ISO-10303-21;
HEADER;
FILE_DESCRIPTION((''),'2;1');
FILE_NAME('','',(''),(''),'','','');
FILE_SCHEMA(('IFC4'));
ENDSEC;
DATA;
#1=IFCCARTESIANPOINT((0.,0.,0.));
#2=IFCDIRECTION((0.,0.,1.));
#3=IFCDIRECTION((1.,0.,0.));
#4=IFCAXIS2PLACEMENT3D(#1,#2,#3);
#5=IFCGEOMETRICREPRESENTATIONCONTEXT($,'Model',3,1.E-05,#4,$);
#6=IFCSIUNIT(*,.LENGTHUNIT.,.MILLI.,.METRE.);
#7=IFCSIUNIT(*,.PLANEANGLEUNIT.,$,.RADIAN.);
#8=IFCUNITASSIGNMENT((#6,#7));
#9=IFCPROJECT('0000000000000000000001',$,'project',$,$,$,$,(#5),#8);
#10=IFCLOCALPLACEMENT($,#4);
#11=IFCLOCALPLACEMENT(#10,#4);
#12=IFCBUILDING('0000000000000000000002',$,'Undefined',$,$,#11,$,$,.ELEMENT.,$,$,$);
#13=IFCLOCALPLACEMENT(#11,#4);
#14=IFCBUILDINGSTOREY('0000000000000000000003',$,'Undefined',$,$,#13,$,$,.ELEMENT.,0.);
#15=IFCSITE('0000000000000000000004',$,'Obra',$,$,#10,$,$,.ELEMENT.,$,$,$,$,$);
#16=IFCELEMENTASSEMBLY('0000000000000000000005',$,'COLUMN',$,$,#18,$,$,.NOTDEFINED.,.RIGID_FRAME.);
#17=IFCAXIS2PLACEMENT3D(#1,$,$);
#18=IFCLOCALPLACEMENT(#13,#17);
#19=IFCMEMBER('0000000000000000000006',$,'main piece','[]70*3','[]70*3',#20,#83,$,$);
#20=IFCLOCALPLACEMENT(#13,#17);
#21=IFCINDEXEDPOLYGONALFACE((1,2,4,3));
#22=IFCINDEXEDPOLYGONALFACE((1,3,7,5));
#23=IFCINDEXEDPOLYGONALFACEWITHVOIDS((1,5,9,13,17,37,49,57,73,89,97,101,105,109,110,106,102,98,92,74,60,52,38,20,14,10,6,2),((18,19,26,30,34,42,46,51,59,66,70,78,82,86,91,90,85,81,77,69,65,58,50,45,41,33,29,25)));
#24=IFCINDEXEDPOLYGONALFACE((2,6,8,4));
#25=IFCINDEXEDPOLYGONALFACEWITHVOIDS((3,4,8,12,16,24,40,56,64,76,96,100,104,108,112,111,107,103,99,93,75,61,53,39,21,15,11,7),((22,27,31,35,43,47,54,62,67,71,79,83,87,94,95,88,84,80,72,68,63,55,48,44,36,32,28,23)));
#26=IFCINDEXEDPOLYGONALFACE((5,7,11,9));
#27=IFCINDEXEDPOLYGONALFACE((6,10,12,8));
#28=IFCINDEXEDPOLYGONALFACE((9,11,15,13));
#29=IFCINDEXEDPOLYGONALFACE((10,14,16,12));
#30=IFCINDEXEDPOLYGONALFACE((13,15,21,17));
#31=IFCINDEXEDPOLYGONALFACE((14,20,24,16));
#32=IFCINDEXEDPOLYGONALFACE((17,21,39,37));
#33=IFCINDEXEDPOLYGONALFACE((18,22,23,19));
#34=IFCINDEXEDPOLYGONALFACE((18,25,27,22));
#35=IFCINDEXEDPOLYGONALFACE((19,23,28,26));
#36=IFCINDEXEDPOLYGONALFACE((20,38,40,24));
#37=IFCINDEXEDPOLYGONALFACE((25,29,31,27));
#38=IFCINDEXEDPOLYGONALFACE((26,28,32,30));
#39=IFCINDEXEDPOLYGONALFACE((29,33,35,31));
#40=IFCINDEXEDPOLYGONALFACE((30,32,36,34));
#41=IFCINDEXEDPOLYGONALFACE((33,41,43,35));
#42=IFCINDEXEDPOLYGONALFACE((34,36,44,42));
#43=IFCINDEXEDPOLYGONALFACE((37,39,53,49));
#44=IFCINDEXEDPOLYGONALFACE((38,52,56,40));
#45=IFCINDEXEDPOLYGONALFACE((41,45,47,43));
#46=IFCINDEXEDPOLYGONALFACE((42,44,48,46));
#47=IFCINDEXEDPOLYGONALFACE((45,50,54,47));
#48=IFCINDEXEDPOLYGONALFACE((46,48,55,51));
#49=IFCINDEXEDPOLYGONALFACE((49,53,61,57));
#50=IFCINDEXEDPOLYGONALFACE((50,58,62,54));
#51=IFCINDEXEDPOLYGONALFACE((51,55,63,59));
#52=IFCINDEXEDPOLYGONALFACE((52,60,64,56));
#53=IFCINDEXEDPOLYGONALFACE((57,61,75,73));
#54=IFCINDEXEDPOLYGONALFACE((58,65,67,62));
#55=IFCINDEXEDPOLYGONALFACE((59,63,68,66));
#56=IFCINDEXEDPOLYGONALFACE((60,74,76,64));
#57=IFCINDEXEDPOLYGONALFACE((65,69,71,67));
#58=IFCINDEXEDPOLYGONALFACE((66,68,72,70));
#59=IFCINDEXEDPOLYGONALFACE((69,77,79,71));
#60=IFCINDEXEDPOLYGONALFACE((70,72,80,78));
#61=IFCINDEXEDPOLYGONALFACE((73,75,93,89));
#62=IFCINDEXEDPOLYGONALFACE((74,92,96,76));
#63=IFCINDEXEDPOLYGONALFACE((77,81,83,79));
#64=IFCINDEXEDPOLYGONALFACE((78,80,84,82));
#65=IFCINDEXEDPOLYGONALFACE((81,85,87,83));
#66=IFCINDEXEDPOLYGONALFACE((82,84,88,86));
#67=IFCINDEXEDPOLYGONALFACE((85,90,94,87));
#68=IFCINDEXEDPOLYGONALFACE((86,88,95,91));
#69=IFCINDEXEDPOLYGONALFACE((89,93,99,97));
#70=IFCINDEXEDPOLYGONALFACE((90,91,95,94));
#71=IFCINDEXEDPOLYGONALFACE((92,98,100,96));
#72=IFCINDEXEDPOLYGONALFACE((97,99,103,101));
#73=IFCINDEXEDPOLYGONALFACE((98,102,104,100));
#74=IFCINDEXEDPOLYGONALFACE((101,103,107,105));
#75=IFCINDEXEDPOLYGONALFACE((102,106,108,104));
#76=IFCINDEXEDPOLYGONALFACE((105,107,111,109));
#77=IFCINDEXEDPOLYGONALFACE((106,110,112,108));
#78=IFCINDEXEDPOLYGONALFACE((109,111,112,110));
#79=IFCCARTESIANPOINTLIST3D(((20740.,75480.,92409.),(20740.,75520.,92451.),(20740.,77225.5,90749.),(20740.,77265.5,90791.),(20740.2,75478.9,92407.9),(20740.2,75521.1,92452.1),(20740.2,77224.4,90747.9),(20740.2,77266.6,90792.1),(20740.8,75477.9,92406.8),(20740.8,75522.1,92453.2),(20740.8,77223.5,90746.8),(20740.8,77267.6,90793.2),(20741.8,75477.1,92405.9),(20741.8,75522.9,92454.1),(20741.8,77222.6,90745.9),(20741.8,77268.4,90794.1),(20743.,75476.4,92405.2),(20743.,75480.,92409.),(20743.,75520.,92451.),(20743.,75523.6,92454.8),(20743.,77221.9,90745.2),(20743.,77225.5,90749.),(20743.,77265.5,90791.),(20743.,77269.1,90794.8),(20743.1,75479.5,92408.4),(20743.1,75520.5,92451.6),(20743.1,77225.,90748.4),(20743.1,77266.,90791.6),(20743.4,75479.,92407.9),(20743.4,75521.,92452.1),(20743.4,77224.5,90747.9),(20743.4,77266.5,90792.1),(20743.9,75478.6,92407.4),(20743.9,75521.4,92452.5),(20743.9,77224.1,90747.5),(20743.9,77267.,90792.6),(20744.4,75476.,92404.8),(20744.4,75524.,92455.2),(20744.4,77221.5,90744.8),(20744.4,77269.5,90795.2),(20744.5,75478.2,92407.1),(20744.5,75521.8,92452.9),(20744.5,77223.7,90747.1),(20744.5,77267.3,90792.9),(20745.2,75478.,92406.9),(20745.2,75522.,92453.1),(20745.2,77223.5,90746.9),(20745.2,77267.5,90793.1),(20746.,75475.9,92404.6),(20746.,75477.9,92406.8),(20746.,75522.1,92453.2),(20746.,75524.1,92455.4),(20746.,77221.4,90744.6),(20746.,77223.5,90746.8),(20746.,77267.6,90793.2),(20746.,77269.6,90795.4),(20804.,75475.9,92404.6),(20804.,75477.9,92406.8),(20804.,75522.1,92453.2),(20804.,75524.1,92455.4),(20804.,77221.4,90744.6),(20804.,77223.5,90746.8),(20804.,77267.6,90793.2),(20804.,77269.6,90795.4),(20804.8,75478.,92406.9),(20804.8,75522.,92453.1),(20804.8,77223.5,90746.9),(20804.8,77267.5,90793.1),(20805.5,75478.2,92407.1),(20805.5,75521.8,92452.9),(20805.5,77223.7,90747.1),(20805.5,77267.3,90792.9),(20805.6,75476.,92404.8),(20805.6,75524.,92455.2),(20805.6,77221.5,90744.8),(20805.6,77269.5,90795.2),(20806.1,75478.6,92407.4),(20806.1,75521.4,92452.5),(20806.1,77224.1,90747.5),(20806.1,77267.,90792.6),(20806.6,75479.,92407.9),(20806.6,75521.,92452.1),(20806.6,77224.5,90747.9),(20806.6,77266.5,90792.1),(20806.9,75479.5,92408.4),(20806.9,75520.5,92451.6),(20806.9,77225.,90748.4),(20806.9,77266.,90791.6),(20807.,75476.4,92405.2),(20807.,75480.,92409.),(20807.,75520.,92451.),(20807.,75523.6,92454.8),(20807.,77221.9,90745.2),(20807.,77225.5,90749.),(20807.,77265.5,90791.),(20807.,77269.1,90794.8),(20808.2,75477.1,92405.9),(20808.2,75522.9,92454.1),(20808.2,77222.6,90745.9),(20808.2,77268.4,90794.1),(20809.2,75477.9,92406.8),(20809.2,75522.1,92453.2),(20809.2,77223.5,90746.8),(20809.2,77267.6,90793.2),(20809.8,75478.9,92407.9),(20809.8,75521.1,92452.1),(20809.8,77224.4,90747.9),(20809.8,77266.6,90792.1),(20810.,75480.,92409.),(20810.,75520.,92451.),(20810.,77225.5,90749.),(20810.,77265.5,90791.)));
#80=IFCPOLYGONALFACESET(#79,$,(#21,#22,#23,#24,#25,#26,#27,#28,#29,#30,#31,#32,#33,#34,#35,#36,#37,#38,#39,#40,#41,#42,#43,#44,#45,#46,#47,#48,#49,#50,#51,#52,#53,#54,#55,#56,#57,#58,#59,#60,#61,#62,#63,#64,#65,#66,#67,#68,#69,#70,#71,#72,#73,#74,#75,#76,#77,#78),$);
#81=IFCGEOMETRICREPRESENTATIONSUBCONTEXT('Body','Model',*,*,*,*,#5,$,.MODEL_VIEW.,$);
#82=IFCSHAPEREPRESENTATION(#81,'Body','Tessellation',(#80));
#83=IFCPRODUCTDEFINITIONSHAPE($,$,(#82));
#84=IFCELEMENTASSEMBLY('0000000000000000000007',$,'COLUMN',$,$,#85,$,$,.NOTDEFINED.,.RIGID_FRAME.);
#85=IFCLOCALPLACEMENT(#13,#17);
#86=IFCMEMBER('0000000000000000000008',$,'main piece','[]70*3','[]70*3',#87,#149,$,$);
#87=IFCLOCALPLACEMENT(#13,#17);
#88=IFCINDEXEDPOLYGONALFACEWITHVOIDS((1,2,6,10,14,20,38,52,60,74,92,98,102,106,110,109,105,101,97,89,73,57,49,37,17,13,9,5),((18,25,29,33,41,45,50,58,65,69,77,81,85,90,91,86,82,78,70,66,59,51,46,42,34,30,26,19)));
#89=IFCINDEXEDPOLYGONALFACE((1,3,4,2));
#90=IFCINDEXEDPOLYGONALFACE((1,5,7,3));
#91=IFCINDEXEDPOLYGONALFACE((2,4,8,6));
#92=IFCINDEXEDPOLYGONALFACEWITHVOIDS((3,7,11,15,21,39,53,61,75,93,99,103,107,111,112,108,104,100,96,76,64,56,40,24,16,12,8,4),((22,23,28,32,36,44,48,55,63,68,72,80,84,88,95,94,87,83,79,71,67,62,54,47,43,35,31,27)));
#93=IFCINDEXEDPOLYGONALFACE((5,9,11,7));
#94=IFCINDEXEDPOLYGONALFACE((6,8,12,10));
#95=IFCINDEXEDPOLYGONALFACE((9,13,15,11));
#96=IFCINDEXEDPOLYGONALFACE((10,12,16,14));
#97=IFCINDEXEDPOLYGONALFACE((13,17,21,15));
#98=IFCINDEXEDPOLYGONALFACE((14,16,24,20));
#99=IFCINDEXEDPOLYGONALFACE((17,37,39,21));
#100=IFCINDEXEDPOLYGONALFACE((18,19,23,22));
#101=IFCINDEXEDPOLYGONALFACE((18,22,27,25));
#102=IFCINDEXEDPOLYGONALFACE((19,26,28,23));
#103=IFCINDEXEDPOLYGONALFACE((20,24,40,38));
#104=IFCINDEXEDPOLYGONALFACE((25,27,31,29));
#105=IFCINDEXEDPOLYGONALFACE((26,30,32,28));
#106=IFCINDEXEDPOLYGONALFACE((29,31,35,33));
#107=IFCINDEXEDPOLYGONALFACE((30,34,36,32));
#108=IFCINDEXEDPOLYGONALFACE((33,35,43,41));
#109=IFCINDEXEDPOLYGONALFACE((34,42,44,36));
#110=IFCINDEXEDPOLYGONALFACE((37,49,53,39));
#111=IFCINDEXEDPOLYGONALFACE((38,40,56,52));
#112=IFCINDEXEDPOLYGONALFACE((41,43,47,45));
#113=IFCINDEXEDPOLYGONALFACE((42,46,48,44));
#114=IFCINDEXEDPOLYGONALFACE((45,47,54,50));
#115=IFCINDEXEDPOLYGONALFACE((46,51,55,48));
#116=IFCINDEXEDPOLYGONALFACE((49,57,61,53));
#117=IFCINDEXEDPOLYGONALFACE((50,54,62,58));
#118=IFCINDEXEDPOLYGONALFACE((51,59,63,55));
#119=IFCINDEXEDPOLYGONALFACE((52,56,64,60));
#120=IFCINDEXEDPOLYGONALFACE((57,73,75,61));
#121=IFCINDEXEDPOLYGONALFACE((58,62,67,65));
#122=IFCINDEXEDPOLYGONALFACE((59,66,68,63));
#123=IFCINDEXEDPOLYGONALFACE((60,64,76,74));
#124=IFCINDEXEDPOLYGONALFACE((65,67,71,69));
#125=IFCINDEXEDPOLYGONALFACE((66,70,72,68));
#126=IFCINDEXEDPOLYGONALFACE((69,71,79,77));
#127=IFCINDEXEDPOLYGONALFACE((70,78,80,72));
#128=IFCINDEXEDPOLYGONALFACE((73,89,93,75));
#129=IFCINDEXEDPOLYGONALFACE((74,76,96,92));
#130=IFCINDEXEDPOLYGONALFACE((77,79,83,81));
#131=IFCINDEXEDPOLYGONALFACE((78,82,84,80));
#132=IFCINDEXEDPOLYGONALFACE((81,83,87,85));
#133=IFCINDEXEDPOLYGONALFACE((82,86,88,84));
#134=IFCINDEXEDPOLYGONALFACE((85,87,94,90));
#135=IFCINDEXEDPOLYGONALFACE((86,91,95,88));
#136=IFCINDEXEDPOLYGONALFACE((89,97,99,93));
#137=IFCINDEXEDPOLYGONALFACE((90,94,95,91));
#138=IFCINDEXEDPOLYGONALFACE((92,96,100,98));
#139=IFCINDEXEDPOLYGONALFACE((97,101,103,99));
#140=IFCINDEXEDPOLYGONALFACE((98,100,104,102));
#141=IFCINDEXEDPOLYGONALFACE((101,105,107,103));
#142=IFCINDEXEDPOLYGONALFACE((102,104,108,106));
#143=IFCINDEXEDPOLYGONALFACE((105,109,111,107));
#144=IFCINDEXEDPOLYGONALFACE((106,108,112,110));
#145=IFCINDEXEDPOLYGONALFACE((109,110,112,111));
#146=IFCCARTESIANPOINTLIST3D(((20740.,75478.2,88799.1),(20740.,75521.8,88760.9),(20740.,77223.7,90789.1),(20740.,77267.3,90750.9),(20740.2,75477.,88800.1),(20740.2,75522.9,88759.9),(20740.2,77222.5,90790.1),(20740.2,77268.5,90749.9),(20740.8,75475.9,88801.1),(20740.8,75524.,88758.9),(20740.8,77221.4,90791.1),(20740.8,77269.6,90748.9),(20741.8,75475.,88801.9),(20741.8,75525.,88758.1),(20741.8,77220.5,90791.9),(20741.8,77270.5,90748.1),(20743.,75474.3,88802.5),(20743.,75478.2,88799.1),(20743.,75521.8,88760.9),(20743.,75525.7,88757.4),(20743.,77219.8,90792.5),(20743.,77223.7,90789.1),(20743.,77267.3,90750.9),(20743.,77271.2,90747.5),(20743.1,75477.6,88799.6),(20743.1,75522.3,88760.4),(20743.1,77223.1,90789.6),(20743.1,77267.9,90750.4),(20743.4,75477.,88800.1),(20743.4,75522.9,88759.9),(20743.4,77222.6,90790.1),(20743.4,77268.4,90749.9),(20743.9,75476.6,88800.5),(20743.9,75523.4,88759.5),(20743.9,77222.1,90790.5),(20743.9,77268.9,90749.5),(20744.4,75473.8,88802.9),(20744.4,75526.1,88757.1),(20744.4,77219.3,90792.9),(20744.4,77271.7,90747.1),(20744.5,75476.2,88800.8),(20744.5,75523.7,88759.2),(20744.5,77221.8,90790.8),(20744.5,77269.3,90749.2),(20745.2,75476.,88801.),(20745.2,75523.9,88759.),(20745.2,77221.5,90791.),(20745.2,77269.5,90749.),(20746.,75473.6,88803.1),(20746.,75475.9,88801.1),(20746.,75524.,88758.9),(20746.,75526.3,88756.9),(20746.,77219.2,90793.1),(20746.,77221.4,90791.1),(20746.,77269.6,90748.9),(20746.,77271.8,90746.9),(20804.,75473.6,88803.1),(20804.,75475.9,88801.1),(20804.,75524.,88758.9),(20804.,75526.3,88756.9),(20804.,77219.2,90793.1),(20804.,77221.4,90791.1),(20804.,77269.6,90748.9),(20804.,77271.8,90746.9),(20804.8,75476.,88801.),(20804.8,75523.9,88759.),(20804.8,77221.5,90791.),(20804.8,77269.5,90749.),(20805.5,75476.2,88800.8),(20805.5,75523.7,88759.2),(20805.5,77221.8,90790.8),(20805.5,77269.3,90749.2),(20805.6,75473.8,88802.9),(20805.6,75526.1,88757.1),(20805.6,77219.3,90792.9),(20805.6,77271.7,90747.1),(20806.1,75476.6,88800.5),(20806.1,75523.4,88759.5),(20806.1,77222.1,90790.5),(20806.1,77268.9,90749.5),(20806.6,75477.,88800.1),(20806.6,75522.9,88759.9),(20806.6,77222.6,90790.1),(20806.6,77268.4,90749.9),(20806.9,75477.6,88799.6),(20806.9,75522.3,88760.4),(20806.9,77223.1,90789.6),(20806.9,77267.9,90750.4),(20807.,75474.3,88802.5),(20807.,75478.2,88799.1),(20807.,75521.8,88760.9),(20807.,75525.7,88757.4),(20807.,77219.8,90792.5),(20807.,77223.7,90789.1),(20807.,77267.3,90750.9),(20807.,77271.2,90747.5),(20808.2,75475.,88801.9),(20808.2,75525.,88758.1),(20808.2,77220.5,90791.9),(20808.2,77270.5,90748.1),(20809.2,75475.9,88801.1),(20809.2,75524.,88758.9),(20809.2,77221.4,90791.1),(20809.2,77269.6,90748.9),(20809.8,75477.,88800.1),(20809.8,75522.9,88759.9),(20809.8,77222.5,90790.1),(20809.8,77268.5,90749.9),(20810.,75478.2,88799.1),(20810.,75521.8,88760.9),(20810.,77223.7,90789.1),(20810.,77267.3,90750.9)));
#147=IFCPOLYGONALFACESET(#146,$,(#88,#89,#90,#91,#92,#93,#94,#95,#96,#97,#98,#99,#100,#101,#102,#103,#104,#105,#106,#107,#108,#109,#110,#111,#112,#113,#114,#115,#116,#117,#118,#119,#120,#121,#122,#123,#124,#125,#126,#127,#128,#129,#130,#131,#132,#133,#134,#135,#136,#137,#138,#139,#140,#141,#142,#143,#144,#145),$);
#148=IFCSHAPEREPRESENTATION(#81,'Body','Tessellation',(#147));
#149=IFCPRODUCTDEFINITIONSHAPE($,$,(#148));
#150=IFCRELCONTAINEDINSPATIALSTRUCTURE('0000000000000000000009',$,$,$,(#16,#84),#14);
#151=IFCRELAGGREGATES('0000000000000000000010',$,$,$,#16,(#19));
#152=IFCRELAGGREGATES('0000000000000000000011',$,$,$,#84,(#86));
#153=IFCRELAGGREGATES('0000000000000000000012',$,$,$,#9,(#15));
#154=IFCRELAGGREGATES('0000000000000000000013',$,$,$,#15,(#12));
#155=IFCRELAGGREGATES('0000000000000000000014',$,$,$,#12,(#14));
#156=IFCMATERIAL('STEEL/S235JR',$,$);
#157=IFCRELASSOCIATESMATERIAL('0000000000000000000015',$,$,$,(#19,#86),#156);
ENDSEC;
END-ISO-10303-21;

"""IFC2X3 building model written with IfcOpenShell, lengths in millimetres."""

from ifc_helpers import new_model, si_unit, frame, origin_with_axes, origin_2d_with_axis, place, context, subcontext, project, spatial, hollow_rectangle, extrude, material, element, aggregate, save


model = new_model("IFC2X3")

# Units and contexts
model_context = context("Model", 3, precision=1e-05, world=origin_with_axes())
body_context = subcontext(model_context, "Body", "Model", "MODEL_VIEW")
ifc_project = project(units=[si_unit("LENGTHUNIT", "METRE", prefix="MILLI"), si_unit("PLANEANGLEUNIT", "RADIAN")], contexts=[model_context])

# Site, building, storey
site_placement = place(None, origin_with_axes())
site = spatial("IfcSite", under=ifc_project, at=site_placement, Name="Obra", CompositionType="ELEMENT")
building_placement = place(site_placement, origin_with_axes())
building = spatial("IfcBuilding", under=site, at=building_placement, Name="Undefined", CompositionType="ELEMENT")
storey_placement = place(building_placement, origin_with_axes())
storey = spatial("IfcBuildingStorey", under=building, at=storey_placement, Name="Undefined", CompositionType="ELEMENT", Elevation=0.0)

# Shared definitions
ifc_material = material(Name="STEEL/S235JR")

# Element assemblies, members
assembly_1_placement = place(storey_placement, origin_with_axes())
assembly_1 = element("IfcElementAssembly", 1, at=assembly_1_placement, inside=storey, Name="COLUMN", AssemblyPlace="NOTDEFINED", PredefinedType="RIGID_FRAME")
member_1_placement = place(assembly_1_placement, frame((20775.0, 77245.5, 90770.0), z_axis=(1.0, 0.0, 0.0), x_axis=(0.0, -0.724633, 0.689135)))
member_1 = element("IfcMember", 2, at=member_1_placement, material=ifc_material, Name="main piece", Description="[]70*3", ObjectType="[]70*3", context=body_context, shape_type="SweptSolid", body=[
    extrude(hollow_rectangle(XDim=70.0, YDim=70.0, WallThickness=3.0, InnerFilletRadius=3.0, OuterFilletRadius=6.0, at=origin_2d_with_axis()), frame((2408.8, 0.0, 0.0), z_axis=(-1.0, 0.0, 0.0), x_axis=(0.0, -1.0, 0.0)), (0.0, 0.0, 1.0), 2408.8),
])
aggregate(assembly_1, [member_1])
assembly_2_placement = place(storey_placement, origin_with_axes())
assembly_2 = element("IfcElementAssembly", 3, at=assembly_2_placement, inside=storey, Name="COLUMN", AssemblyPlace="NOTDEFINED", PredefinedType="RIGID_FRAME")
member_2_placement = place(assembly_2_placement, frame((20775.0, 75500.0, 88780.0), z_axis=(-1.0, 0.0, 0.0), x_axis=(0.0, 0.659423, 0.751772)))
member_2 = element("IfcMember", 4, at=member_2_placement, material=ifc_material, Name="main piece", Description="[]70*3", ObjectType="[]70*3", context=body_context, shape_type="SweptSolid", body=[
    extrude(hollow_rectangle(XDim=70.0, YDim=70.0, WallThickness=3.0, InnerFilletRadius=3.0, OuterFilletRadius=6.0, at=origin_2d_with_axis()), frame((2647.1, 0.0, 0.0), z_axis=(-1.0, 0.0, 0.0), x_axis=(0.0, -1.0, 0.0)), (0.0, 0.0, 1.0), 2647.1),
])
aggregate(assembly_2, [member_2])

save(model, "model.ifc")
